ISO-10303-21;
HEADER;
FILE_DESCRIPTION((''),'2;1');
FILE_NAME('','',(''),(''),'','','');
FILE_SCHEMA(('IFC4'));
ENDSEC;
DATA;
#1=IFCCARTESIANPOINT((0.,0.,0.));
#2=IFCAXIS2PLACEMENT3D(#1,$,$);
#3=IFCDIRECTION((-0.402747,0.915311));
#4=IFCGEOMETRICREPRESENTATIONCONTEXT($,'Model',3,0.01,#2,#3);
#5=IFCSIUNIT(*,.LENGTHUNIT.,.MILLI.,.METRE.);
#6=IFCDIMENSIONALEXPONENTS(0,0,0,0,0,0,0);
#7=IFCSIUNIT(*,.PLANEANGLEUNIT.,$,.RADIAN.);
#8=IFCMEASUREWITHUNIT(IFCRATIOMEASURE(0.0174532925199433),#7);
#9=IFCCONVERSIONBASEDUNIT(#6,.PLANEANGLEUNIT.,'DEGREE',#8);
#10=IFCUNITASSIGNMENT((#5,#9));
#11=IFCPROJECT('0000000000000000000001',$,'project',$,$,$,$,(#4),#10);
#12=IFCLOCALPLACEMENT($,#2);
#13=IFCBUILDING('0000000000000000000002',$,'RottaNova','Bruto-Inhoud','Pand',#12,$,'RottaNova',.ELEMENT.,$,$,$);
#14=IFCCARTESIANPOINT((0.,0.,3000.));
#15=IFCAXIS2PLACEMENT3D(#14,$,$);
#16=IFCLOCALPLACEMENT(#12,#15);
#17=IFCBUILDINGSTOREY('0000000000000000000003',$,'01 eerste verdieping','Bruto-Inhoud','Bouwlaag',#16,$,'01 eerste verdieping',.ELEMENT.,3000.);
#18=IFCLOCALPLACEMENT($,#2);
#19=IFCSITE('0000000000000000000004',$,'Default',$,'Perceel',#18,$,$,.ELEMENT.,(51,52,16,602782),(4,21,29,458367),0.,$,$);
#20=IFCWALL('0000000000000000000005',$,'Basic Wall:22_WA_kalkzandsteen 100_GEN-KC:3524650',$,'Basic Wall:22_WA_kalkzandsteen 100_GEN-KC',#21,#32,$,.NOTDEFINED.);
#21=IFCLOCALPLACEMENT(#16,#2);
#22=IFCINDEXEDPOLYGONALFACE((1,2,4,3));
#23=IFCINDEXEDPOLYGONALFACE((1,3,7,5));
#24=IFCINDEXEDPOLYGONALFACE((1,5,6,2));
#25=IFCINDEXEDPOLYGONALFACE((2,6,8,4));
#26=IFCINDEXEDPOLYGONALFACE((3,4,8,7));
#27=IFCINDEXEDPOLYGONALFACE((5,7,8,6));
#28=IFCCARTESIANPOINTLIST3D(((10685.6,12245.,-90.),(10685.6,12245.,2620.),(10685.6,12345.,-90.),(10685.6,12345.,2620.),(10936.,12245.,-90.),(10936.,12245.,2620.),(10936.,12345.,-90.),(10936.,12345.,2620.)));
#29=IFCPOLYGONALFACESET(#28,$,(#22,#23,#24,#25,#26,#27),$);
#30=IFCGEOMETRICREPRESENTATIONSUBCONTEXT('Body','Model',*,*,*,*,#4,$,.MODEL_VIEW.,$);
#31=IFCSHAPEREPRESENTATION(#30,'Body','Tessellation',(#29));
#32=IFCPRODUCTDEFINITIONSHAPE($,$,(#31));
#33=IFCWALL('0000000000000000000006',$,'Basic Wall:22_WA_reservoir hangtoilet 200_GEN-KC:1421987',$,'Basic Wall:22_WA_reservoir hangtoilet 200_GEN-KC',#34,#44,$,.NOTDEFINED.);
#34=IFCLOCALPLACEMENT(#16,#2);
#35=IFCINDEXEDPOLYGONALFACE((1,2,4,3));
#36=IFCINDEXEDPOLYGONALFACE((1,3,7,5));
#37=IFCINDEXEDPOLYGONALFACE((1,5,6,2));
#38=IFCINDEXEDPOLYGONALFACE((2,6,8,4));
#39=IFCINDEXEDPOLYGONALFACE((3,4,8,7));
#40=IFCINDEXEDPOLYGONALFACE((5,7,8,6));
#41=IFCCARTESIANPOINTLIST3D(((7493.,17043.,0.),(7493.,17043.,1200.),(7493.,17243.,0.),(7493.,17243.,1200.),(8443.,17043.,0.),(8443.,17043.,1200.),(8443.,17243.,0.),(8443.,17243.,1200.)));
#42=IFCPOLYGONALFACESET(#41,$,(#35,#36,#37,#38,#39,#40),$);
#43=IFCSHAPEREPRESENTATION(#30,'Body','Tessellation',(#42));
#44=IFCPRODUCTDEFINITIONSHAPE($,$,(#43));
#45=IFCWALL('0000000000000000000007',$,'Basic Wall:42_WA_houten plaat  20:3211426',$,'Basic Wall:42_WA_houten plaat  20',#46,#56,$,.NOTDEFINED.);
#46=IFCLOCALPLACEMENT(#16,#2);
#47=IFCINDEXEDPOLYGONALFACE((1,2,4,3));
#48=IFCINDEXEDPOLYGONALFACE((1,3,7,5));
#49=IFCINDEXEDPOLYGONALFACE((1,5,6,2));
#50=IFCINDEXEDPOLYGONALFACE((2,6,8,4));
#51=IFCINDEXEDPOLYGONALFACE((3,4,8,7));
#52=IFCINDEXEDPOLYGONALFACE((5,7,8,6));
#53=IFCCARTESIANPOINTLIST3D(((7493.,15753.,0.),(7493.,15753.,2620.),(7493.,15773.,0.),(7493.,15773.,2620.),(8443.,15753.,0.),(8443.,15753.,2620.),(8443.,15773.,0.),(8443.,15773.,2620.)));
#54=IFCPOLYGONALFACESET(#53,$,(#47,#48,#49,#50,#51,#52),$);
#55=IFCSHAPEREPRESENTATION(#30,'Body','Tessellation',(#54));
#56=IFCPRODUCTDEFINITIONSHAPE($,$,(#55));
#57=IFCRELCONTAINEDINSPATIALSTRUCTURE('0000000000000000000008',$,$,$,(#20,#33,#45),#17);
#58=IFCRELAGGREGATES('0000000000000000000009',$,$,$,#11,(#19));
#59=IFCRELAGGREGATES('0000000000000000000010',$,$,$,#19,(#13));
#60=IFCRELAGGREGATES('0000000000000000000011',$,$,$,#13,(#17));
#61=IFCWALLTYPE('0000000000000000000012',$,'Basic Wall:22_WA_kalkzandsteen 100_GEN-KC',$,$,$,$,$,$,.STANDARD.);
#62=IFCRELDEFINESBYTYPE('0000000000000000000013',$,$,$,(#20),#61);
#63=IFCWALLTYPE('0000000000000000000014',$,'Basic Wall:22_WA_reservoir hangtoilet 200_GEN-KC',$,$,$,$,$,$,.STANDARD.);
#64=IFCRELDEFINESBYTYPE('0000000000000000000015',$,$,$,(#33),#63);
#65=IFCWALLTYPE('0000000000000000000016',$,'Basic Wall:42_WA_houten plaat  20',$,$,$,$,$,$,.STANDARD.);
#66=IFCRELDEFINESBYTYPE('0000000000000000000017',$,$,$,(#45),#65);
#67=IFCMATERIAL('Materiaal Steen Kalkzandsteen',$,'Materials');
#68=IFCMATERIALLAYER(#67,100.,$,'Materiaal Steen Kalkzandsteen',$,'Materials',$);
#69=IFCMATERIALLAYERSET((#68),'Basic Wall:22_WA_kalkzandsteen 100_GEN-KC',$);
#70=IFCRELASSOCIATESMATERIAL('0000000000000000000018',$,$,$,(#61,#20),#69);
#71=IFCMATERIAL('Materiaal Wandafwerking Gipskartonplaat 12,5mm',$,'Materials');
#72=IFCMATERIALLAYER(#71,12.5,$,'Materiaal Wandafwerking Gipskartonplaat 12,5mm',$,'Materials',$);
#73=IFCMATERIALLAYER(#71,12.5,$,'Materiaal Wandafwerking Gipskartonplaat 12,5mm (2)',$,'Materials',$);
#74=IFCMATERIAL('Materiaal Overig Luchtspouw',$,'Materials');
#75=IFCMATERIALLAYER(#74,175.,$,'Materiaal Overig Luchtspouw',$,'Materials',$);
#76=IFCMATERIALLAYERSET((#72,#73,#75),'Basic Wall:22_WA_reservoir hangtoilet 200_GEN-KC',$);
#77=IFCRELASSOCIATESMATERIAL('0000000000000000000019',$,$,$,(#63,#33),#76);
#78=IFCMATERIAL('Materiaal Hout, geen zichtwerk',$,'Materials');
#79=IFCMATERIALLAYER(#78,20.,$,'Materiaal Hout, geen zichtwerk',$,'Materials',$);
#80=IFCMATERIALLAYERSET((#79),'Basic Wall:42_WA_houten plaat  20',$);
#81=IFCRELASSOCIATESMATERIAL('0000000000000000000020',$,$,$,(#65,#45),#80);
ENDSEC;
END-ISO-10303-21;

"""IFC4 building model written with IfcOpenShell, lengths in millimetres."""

from ifc_helpers import new_model, entity, si_unit, converted_unit, direction, frame, frame_2d, origin, place, context, subcontext, project, spatial, rectangle, extrude, material, layer, layer_set, type_object, element, save


model = new_model("IFC4")

# Units and contexts
model_context = context("Model", 3, precision=0.01, world=origin(), true_north=direction((-0.402747, 0.915311)))
body_context = subcontext(model_context, "Body", "Model", "MODEL_VIEW")
ifc_project = project(units=[si_unit("LENGTHUNIT", "METRE", prefix="MILLI"), converted_unit("PLANEANGLEUNIT", "DEGREE", entity("IfcRatioMeasure", 0.0174532925199433), si_unit("PLANEANGLEUNIT", "RADIAN"), dimensions=[0, 0, 0, 0, 0, 0, 0])], contexts=[model_context])

# Site, building, storey
site_placement = place(None, origin())
site = spatial("IfcSite", under=ifc_project, at=site_placement, Name="Default", ObjectType="Perceel", CompositionType="ELEMENT", RefLatitude=(51, 52, 16, 602782), RefLongitude=(4, 21, 29, 458367), RefElevation=0.0)
building_placement = place(None, origin())
building = spatial("IfcBuilding", under=site, at=building_placement, Name="RottaNova", Description="Bruto-Inhoud", ObjectType="Pand", LongName="RottaNova", CompositionType="ELEMENT")
storey_placement = place(building_placement, frame((0.0, 0.0, 3000.0)))
storey = spatial("IfcBuildingStorey", under=building, at=storey_placement, Name="01 eerste verdieping", Description="Bruto-Inhoud", ObjectType="Bouwlaag", LongName="01 eerste verdieping", CompositionType="ELEMENT", Elevation=3000.0)

# Shared definitions
ifc_material_1 = material(Name="Materiaal Steen Kalkzandsteen", Category="Materials")

# Walls
ifc_material_2 = material(Name="Materiaal Wandafwerking Gipskartonplaat 12,5mm", Category="Materials")
ifc_layer_1 = layer(ifc_material_1, 100.0, Name="Materiaal Steen Kalkzandsteen", Category="Materials")
ifc_layer_set_1 = layer_set([ifc_layer_1], Name="Basic Wall:22_WA_kalkzandsteen 100_GEN-KC")
wall_type_1 = type_object("IfcWallType", Name="Basic Wall:22_WA_kalkzandsteen 100_GEN-KC", PredefinedType="STANDARD", material=ifc_layer_set_1)
wall_1_placement = place(storey_placement, frame((10685.6, 12295.0, -90.0)))
element("IfcWall", 1, at=wall_1_placement, inside=storey, type_object=wall_type_1, material=ifc_layer_set_1, Name="Basic Wall:22_WA_kalkzandsteen 100_GEN-KC:3524650", ObjectType="Basic Wall:22_WA_kalkzandsteen 100_GEN-KC", PredefinedType="NOTDEFINED", context=body_context, shape_type="SweptSolid", body=[
    extrude(rectangle(XDim=250.4, YDim=100.0, at=frame_2d((125.2, 0.0), x_axis=(-1.0, 0.0))), origin(), (0.0, 0.0, 1.0), 2710.0),
])
ifc_layer_2 = layer(ifc_material_2, 12.5, Name="Materiaal Wandafwerking Gipskartonplaat 12,5mm", Category="Materials")
ifc_layer_3 = layer(ifc_material_2, 12.5, Name="Materiaal Wandafwerking Gipskartonplaat 12,5mm (2)", Category="Materials")
ifc_material_3 = material(Name="Materiaal Overig Luchtspouw", Category="Materials")
ifc_layer_4 = layer(ifc_material_3, 175.0, Name="Materiaal Overig Luchtspouw", Category="Materials")
ifc_layer_set_2 = layer_set([ifc_layer_2, ifc_layer_3, ifc_layer_4], Name="Basic Wall:22_WA_reservoir hangtoilet 200_GEN-KC")
wall_type_2 = type_object("IfcWallType", Name="Basic Wall:22_WA_reservoir hangtoilet 200_GEN-KC", PredefinedType="STANDARD", material=ifc_layer_set_2)
wall_2_placement = place(storey_placement, frame((7493.0, 17143.0, 0.0)))
element("IfcWall", 2, at=wall_2_placement, inside=storey, type_object=wall_type_2, material=ifc_layer_set_2, Name="Basic Wall:22_WA_reservoir hangtoilet 200_GEN-KC:1421987", ObjectType="Basic Wall:22_WA_reservoir hangtoilet 200_GEN-KC", PredefinedType="NOTDEFINED", context=body_context, shape_type="SweptSolid", body=[
    extrude(rectangle(XDim=950.0, YDim=200.0, at=frame_2d((475.0, 0.0), x_axis=(-1.0, 0.0))), origin(), (0.0, 0.0, 1.0), 1200.0),
])
ifc_material_4 = material(Name="Materiaal Hout, geen zichtwerk", Category="Materials")
ifc_layer_5 = layer(ifc_material_4, 20.0, Name="Materiaal Hout, geen zichtwerk", Category="Materials")
ifc_layer_set_3 = layer_set([ifc_layer_5], Name="Basic Wall:42_WA_houten plaat  20")
wall_type_3 = type_object("IfcWallType", Name="Basic Wall:42_WA_houten plaat  20", PredefinedType="STANDARD", material=ifc_layer_set_3)
wall_3_placement = place(storey_placement, frame((7493.0, 15763.0, 0.0)))
element("IfcWall", 3, at=wall_3_placement, inside=storey, type_object=wall_type_3, material=ifc_layer_set_3, Name="Basic Wall:42_WA_houten plaat  20:3211426", ObjectType="Basic Wall:42_WA_houten plaat  20", PredefinedType="NOTDEFINED", context=body_context, shape_type="SweptSolid", body=[
    extrude(rectangle(XDim=950.0, YDim=20.0, at=frame_2d((475.0, 0.0), x_axis=(-1.0, 0.0))), origin(), (0.0, 0.0, 1.0), 2620.0),
])

save(model, "model.ifc")
